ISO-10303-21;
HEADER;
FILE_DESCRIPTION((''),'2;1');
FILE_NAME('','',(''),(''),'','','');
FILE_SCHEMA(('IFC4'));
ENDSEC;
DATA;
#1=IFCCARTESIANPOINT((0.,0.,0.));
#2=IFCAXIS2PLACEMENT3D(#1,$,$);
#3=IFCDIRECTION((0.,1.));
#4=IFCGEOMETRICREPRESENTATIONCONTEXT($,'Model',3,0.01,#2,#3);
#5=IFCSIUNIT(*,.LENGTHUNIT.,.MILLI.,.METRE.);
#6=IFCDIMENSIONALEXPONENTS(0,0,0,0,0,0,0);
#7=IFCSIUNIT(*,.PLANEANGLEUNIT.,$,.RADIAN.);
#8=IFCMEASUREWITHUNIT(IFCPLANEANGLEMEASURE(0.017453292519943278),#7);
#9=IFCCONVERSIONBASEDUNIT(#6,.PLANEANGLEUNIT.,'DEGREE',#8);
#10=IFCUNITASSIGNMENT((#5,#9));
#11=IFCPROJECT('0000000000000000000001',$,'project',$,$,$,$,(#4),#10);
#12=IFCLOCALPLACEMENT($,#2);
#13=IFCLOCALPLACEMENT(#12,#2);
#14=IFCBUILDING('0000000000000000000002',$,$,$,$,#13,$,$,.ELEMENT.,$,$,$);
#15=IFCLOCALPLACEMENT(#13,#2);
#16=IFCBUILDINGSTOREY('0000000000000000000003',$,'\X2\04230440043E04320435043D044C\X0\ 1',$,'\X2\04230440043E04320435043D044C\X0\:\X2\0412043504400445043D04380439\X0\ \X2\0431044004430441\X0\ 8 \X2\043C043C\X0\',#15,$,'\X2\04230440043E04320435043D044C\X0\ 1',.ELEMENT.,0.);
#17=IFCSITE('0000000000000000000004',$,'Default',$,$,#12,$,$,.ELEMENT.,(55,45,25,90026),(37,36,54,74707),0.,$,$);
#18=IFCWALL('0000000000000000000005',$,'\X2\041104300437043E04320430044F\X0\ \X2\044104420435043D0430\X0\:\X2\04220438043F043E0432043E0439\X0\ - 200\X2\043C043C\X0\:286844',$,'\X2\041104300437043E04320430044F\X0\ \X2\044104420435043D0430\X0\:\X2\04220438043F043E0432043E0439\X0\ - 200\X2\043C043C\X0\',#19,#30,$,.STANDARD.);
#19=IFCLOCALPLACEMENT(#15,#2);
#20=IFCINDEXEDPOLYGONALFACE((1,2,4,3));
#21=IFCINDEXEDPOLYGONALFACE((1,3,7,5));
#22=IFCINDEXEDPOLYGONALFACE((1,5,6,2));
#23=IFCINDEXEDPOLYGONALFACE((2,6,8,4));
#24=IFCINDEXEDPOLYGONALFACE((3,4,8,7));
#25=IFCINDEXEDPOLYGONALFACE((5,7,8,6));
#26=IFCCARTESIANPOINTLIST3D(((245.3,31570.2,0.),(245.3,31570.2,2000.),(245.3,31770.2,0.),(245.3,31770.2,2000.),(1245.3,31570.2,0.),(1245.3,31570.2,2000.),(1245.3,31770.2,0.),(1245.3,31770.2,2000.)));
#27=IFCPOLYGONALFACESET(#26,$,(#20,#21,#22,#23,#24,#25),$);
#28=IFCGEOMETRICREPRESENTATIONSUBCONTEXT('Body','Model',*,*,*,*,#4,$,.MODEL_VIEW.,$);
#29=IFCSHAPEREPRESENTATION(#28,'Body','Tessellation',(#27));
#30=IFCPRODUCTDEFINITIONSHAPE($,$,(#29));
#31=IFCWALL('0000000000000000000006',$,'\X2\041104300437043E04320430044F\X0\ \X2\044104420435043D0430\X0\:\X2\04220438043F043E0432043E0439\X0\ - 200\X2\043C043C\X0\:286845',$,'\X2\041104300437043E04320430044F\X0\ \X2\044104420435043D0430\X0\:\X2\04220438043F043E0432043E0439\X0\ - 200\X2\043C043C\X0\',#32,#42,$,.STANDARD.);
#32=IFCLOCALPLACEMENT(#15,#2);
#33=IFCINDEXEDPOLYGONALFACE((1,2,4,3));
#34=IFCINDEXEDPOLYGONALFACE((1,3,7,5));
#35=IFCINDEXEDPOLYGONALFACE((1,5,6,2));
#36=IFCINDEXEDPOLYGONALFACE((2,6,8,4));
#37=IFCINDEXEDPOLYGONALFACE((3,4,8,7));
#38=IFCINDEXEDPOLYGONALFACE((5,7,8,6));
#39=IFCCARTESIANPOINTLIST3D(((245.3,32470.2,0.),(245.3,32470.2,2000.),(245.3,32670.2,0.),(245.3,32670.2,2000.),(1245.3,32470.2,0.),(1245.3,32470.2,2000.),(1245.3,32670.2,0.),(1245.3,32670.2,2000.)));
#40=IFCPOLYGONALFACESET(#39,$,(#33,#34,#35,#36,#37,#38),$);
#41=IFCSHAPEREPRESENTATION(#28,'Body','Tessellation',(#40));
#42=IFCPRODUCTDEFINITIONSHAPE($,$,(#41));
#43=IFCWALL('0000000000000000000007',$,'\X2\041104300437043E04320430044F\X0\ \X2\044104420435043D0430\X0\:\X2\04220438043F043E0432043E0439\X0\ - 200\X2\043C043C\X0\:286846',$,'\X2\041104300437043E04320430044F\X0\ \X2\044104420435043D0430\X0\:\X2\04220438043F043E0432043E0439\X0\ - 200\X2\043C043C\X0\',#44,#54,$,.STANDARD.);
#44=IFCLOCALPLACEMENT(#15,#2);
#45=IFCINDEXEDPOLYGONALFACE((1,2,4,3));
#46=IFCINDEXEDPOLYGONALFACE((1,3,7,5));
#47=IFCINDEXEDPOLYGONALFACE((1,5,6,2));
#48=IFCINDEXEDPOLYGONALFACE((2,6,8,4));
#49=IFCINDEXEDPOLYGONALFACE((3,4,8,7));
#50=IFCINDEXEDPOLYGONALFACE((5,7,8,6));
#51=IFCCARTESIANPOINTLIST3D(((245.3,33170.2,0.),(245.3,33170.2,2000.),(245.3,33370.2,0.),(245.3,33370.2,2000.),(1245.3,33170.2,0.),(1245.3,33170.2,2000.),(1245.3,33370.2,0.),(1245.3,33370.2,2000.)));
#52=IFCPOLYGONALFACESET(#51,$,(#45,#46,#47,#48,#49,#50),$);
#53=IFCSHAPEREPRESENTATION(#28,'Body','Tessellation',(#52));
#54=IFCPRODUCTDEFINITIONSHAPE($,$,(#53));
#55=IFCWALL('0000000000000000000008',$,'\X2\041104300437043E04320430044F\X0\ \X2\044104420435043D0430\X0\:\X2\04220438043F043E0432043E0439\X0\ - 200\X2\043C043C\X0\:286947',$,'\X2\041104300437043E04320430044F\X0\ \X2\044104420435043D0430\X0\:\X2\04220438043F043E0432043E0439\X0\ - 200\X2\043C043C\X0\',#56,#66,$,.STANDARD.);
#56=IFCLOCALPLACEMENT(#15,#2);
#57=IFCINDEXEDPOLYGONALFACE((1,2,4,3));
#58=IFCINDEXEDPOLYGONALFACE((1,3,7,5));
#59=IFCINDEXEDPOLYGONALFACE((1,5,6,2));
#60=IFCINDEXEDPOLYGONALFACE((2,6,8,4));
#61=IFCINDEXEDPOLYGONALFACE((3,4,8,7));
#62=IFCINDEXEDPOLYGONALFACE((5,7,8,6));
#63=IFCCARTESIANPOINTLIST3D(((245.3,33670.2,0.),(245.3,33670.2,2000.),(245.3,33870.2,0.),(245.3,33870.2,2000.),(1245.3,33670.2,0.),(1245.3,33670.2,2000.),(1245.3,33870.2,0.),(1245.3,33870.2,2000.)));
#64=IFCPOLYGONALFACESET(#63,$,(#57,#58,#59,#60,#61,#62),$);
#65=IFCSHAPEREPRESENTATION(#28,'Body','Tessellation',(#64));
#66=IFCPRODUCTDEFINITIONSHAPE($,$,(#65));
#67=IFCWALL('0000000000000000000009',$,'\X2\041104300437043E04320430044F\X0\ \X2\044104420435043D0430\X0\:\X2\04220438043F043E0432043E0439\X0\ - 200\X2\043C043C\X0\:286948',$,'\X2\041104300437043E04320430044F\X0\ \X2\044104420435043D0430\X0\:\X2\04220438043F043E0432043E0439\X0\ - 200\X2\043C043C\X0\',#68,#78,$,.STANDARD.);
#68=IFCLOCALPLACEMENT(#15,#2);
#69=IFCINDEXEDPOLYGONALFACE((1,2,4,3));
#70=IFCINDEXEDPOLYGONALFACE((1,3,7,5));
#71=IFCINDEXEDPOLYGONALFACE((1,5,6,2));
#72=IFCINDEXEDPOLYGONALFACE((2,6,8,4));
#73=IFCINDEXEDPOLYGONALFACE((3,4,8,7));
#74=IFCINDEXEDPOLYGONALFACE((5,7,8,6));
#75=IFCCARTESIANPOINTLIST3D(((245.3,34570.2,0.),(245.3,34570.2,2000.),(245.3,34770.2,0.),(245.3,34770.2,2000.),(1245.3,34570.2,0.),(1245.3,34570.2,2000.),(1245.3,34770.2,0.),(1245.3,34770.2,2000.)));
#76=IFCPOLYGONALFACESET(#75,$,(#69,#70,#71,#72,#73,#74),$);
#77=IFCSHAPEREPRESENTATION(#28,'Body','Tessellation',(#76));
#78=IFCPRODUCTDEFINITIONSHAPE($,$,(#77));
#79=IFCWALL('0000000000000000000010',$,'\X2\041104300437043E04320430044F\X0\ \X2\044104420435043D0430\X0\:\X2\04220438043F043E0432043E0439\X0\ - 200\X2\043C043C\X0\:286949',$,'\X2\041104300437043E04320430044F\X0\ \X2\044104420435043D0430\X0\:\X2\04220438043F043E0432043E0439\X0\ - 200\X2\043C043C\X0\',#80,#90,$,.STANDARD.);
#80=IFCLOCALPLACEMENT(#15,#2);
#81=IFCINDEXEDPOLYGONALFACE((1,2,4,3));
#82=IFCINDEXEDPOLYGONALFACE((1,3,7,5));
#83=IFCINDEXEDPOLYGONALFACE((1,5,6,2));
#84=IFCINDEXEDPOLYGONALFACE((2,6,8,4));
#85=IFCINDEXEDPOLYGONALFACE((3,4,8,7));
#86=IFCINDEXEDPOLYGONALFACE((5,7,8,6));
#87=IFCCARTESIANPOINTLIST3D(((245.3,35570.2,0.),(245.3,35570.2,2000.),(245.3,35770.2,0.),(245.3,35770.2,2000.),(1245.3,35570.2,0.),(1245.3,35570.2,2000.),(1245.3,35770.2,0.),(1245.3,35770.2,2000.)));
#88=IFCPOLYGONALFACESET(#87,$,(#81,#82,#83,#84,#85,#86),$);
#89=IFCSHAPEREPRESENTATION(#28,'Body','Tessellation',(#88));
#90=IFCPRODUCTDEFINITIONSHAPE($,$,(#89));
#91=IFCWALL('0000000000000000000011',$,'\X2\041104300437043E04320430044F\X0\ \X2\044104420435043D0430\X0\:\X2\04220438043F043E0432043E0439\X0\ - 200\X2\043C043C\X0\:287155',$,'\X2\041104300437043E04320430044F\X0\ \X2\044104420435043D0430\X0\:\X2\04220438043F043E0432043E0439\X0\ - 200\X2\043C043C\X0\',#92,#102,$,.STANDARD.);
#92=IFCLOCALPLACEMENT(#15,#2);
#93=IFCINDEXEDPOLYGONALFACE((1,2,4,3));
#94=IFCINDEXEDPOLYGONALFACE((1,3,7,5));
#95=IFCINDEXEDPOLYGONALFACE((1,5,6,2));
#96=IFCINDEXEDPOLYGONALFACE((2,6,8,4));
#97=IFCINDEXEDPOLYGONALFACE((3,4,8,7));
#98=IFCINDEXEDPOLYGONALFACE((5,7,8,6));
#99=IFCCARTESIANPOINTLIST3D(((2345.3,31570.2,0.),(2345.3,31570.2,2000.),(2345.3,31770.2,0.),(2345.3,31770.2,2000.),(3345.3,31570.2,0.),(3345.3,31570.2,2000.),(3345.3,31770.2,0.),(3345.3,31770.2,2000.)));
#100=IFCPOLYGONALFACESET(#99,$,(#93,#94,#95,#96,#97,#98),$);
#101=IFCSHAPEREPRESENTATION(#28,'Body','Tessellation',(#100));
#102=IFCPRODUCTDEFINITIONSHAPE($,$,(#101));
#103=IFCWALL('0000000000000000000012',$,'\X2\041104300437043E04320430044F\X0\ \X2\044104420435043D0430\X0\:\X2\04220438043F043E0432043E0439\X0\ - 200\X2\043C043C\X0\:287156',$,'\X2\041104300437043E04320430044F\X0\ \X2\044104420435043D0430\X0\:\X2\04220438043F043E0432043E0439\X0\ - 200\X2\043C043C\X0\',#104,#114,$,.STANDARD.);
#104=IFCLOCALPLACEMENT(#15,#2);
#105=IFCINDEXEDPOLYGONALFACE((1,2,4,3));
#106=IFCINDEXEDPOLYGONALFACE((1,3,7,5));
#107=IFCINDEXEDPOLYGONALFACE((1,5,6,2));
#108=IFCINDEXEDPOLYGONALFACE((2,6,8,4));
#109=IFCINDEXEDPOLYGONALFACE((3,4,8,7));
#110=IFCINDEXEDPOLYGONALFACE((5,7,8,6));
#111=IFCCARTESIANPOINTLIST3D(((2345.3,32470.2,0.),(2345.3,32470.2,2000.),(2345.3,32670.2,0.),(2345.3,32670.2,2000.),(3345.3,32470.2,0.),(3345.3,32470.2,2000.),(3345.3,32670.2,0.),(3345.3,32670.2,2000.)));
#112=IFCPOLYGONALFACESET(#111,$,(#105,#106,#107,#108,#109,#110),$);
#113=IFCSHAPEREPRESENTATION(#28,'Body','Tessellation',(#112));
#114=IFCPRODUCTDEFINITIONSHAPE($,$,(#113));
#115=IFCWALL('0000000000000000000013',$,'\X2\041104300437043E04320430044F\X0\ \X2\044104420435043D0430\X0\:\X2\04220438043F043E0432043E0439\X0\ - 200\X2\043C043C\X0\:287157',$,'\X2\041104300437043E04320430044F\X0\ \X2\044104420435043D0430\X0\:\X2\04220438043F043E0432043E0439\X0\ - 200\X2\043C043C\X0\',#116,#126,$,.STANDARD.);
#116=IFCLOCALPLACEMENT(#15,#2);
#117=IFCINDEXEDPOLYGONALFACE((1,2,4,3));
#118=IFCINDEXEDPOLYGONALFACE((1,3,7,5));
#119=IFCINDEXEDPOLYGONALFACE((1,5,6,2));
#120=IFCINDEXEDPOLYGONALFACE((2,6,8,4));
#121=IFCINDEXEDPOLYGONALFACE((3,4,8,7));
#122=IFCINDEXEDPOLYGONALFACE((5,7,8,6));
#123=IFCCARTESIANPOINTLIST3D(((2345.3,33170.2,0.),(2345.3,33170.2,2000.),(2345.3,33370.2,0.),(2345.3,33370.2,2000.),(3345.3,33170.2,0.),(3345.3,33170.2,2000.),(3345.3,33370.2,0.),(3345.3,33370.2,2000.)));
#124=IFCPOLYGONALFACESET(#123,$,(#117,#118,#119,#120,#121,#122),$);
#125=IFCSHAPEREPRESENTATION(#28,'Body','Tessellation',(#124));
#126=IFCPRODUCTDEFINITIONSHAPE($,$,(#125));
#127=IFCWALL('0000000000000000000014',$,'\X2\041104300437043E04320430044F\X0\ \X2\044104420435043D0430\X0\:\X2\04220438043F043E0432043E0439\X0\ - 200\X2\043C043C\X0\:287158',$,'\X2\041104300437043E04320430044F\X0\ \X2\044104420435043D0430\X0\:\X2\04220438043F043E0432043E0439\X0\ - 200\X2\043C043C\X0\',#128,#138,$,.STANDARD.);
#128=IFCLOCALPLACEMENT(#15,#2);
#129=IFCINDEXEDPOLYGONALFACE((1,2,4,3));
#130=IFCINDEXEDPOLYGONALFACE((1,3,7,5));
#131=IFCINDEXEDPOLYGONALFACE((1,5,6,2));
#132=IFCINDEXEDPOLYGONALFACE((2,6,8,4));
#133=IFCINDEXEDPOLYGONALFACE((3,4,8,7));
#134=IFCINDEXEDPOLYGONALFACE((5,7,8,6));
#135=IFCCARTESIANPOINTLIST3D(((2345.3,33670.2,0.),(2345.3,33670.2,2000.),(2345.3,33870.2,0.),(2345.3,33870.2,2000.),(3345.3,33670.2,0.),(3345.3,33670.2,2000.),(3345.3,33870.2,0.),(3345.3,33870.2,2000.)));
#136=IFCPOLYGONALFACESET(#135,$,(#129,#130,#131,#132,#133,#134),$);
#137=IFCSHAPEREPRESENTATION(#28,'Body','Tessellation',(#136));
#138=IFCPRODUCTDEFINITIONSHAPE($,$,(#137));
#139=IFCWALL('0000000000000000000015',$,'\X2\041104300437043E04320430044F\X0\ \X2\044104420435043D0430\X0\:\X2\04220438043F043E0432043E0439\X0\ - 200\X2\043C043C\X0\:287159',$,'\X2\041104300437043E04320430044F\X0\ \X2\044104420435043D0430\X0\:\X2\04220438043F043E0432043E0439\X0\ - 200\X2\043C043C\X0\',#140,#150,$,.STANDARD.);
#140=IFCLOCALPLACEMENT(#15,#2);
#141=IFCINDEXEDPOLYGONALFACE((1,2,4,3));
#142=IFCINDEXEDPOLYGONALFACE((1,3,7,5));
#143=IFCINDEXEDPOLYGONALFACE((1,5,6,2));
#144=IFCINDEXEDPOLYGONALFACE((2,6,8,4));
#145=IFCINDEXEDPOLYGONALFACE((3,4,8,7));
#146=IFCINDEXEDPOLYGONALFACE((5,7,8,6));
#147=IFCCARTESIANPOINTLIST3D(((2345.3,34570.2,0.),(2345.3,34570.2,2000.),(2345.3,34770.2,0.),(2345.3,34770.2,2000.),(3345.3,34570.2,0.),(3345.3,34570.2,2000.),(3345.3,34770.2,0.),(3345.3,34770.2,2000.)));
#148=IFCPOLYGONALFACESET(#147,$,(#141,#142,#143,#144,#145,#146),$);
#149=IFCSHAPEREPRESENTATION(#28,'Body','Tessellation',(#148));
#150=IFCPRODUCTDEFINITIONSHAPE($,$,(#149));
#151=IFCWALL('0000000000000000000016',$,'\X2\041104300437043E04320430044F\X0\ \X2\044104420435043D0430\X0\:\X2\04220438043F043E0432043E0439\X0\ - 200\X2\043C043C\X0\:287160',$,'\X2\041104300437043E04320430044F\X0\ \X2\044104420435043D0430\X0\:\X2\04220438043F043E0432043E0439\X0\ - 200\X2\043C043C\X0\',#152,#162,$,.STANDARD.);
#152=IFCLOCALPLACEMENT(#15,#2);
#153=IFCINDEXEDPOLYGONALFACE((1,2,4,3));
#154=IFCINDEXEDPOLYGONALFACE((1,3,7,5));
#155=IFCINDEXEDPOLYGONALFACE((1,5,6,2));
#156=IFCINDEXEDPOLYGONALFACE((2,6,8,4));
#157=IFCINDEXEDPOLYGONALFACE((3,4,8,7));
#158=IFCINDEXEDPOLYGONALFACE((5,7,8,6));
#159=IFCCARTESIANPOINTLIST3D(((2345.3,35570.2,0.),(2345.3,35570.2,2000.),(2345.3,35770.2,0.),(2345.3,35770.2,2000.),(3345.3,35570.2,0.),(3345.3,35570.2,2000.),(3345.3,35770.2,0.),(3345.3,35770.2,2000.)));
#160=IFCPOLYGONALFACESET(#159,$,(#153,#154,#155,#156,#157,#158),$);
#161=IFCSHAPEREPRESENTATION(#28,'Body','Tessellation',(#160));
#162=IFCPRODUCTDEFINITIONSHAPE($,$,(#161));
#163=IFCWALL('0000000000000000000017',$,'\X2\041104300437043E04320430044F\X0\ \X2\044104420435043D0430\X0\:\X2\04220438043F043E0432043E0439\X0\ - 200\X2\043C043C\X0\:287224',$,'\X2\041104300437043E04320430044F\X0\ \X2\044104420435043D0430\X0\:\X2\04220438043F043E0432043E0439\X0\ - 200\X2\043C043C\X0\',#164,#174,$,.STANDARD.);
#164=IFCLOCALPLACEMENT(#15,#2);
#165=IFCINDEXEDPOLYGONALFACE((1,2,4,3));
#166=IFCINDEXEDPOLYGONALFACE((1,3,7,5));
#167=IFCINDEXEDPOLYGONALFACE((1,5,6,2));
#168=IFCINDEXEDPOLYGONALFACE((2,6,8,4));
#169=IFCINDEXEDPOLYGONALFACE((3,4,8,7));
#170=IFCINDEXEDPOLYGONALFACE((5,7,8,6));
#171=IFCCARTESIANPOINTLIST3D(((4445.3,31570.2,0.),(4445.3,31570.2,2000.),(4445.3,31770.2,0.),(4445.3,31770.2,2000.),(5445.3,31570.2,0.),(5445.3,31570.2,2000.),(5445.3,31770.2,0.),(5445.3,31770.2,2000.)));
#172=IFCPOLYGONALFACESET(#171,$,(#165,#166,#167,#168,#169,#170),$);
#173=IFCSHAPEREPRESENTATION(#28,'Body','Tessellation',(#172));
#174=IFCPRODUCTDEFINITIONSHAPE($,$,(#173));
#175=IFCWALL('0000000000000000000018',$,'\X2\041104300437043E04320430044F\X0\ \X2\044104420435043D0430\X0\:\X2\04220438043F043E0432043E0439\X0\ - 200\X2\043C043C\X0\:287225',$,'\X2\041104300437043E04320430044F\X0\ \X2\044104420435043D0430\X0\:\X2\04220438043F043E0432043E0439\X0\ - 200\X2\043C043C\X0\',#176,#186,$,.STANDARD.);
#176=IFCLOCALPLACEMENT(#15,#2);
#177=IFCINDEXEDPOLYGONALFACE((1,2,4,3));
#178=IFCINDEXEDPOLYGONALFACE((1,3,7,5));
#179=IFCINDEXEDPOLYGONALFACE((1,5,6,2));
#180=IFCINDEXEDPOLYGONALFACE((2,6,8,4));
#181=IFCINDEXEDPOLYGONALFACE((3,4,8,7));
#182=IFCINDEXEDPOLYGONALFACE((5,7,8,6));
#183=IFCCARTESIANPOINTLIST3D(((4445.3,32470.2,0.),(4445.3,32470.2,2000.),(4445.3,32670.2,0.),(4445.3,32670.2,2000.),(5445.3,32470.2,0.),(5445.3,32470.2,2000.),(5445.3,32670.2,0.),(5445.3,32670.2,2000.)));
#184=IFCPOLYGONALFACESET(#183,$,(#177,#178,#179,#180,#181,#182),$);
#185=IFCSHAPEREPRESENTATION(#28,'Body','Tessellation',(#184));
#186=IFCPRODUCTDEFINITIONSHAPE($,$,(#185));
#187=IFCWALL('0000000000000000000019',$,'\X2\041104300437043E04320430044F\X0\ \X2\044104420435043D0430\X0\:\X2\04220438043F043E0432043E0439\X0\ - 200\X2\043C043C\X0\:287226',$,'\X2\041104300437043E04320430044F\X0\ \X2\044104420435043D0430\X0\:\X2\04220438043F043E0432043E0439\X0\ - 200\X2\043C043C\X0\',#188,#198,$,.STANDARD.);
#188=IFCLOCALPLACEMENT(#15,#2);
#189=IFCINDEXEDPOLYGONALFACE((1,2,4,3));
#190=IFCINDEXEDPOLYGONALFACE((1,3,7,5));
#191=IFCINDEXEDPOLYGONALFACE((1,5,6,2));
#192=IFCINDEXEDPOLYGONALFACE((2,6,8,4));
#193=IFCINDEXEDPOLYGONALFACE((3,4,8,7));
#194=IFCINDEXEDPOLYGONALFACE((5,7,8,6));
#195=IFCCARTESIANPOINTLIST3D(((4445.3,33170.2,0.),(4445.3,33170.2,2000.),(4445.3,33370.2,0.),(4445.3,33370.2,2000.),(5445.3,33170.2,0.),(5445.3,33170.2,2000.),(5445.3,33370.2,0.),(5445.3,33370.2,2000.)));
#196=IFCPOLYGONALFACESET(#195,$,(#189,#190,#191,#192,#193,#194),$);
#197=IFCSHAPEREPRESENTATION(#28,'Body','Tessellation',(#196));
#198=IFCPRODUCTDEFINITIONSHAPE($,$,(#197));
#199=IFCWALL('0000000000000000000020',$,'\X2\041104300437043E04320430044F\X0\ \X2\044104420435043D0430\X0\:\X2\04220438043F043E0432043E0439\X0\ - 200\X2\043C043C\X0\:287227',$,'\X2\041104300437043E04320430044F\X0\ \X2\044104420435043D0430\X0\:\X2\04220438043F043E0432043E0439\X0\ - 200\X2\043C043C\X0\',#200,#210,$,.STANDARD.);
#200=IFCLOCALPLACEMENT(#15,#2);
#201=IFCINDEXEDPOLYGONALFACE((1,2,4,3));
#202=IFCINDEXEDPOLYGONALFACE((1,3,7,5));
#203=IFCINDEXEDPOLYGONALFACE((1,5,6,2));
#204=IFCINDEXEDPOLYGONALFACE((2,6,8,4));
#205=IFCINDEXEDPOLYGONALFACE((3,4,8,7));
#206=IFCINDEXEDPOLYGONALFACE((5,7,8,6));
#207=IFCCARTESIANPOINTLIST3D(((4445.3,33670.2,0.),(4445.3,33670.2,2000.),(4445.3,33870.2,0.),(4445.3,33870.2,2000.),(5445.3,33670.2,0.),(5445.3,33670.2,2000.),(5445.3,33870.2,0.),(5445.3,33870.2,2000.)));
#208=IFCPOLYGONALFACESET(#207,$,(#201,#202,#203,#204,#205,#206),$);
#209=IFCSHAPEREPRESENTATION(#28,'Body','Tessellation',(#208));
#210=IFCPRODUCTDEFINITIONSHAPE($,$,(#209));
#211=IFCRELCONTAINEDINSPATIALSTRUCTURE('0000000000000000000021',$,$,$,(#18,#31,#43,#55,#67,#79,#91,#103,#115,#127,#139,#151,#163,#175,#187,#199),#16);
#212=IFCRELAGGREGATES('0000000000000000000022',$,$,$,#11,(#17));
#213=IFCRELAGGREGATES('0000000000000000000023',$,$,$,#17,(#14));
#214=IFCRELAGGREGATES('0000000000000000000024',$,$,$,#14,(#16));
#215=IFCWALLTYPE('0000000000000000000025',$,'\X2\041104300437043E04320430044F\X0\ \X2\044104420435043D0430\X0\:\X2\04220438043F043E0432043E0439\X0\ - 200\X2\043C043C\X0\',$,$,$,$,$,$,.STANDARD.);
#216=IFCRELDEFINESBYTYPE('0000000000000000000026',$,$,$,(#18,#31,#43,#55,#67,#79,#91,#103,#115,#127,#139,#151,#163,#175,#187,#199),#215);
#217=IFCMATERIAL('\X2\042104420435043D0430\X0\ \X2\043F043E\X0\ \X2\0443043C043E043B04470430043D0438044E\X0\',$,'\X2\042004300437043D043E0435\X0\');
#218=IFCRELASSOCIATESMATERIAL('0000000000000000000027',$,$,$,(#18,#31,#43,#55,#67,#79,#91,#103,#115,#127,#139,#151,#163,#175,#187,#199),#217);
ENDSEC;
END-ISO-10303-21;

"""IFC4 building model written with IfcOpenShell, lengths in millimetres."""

from ifc_helpers import new_model, entity, si_unit, converted_unit, direction, frame, origin, place, context, subcontext, project, spatial, indexed_curve, outline, extrude, material, type_object, element, save


model = new_model("IFC4")

# Units and contexts
model_context = context("Model", 3, precision=0.01, world=origin(), true_north=direction((0.0, 1.0)))
body_context = subcontext(model_context, "Body", "Model", "MODEL_VIEW")
ifc_project = project(units=[si_unit("LENGTHUNIT", "METRE", prefix="MILLI"), converted_unit("PLANEANGLEUNIT", "DEGREE", entity("IfcPlaneAngleMeasure", 0.017453292519943278), si_unit("PLANEANGLEUNIT", "RADIAN"), dimensions=[0, 0, 0, 0, 0, 0, 0])], contexts=[model_context])

# Site, building, storey
site_placement = place(None, origin())
site = spatial("IfcSite", under=ifc_project, at=site_placement, Name="Default", CompositionType="ELEMENT", RefLatitude=(55, 45, 25, 90026), RefLongitude=(37, 36, 54, 74707), RefElevation=0.0)
building_placement = place(site_placement, origin())
building = spatial("IfcBuilding", under=site, at=building_placement, CompositionType="ELEMENT")
storey_placement = place(building_placement, origin())
storey = spatial("IfcBuildingStorey", under=building, at=storey_placement, Name="Уровень 1", ObjectType="Уровень:Верхний брус 8 мм", LongName="Уровень 1", CompositionType="ELEMENT", Elevation=0.0)

# Walls
ifc_material = material(Name="Стена по умолчанию", Category="Разное")
wall_type = type_object("IfcWallType", Name="Базовая стена:Типовой - 200мм", PredefinedType="STANDARD")
wall_1_placement = place(storey_placement, frame((245.3, 31670.2, 0.0)))
element("IfcWall", 1, at=wall_1_placement, inside=storey, type_object=wall_type, material=ifc_material, Name="Базовая стена:Типовой - 200мм:286844", ObjectType="Базовая стена:Типовой - 200мм", PredefinedType="STANDARD", context=body_context, shape_type="SweptSolid", body=[
    extrude(outline(indexed_curve([(1000.0, 100.0), (0.0, 100.0), (0.0, -100.0), (1000.0, -100.0), (1000.0, 100.0)], self_intersect=False)), origin(), (0.0, 0.0, 1.0), 2000.0),
])
for number, where, name in (
    (2, (245.3, 32570.2, 0.0), "Базовая стена:Типовой - 200мм:286845"),
    (3, (245.3, 33270.2, 0.0), "Базовая стена:Типовой - 200мм:286846"),
):
    element("IfcWall", number, at=place(storey_placement, frame(where)), inside=storey, type_object=wall_type, material=ifc_material, Name=name, ObjectType="Базовая стена:Типовой - 200мм", PredefinedType="STANDARD", context=body_context, shape_type="SweptSolid", body=[
        extrude(outline(indexed_curve([(1000.0, 100.0), (0.0, 100.0), (0.0, -100.0), (1000.0, -100.0), (1000.0, 100.0)], self_intersect=False)), origin(), (0.0, 0.0, 1.0), 2000.0),
    ])
for number, where, name in (
    (4, (245.3, 33770.2, 0.0), "Базовая стена:Типовой - 200мм:286947"),
    (5, (245.3, 34670.2, 0.0), "Базовая стена:Типовой - 200мм:286948"),
    (6, (245.3, 35670.2, 0.0), "Базовая стена:Типовой - 200мм:286949"),
):
    element("IfcWall", number, at=place(storey_placement, frame(where)), inside=storey, type_object=wall_type, material=ifc_material, Name=name, ObjectType="Базовая стена:Типовой - 200мм", PredefinedType="STANDARD", context=body_context, shape_type="SweptSolid", body=[
        extrude(outline(indexed_curve([(1000.0, 100.0), (0.0, 100.0), (0.0, -100.0), (1000.0, -100.0), (1000.0, 100.0)], self_intersect=False)), origin(), (0.0, 0.0, 1.0), 2000.0),
    ])
wall_2_placement = place(storey_placement, frame((2345.3, 31670.2, 0.0)))
element("IfcWall", 7, at=wall_2_placement, inside=storey, type_object=wall_type, material=ifc_material, Name="Базовая стена:Типовой - 200мм:287155", ObjectType="Базовая стена:Типовой - 200мм", PredefinedType="STANDARD", context=body_context, shape_type="SweptSolid", body=[
    extrude(outline(indexed_curve([(1000.0, 100.0), (0.0, 100.0), (0.0, -100.0), (1000.0, -100.0), (1000.0, 100.0)], self_intersect=False)), origin(), (0.0, 0.0, 1.0), 2000.0),
])
for number, where, name in (
    (8, (2345.3, 32570.2, 0.0), "Базовая стена:Типовой - 200мм:287156"),
    (9, (2345.3, 33270.2, 0.0), "Базовая стена:Типовой - 200мм:287157"),
):
    element("IfcWall", number, at=place(storey_placement, frame(where)), inside=storey, type_object=wall_type, material=ifc_material, Name=name, ObjectType="Базовая стена:Типовой - 200мм", PredefinedType="STANDARD", context=body_context, shape_type="SweptSolid", body=[
        extrude(outline(indexed_curve([(1000.0, 100.0), (0.0, 100.0), (0.0, -100.0), (1000.0, -100.0), (1000.0, 100.0)], self_intersect=False)), origin(), (0.0, 0.0, 1.0), 2000.0),
    ])
for number, where, name in (
    (10, (2345.3, 33770.2, 0.0), "Базовая стена:Типовой - 200мм:287158"),
    (11, (2345.3, 34670.2, 0.0), "Базовая стена:Типовой - 200мм:287159"),
    (12, (2345.3, 35670.2, 0.0), "Базовая стена:Типовой - 200мм:287160"),
):
    element("IfcWall", number, at=place(storey_placement, frame(where)), inside=storey, type_object=wall_type, material=ifc_material, Name=name, ObjectType="Базовая стена:Типовой - 200мм", PredefinedType="STANDARD", context=body_context, shape_type="SweptSolid", body=[
        extrude(outline(indexed_curve([(1000.0, 100.0), (0.0, 100.0), (0.0, -100.0), (1000.0, -100.0), (1000.0, 100.0)], self_intersect=False)), origin(), (0.0, 0.0, 1.0), 2000.0),
    ])
wall_3_placement = place(storey_placement, frame((4445.3, 31670.2, 0.0)))
element("IfcWall", 13, at=wall_3_placement, inside=storey, type_object=wall_type, material=ifc_material, Name="Базовая стена:Типовой - 200мм:287224", ObjectType="Базовая стена:Типовой - 200мм", PredefinedType="STANDARD", context=body_context, shape_type="SweptSolid", body=[
    extrude(outline(indexed_curve([(1000.0, 100.0), (0.0, 100.0), (0.0, -100.0), (1000.0, -100.0), (1000.0, 100.0)], self_intersect=False)), origin(), (0.0, 0.0, 1.0), 2000.0),
])
for number, where, name in (
    (14, (4445.3, 32570.2, 0.0), "Базовая стена:Типовой - 200мм:287225"),
    (15, (4445.3, 33270.2, 0.0), "Базовая стена:Типовой - 200мм:287226"),
):
    element("IfcWall", number, at=place(storey_placement, frame(where)), inside=storey, type_object=wall_type, material=ifc_material, Name=name, ObjectType="Базовая стена:Типовой - 200мм", PredefinedType="STANDARD", context=body_context, shape_type="SweptSolid", body=[
        extrude(outline(indexed_curve([(1000.0, 100.0), (0.0, 100.0), (0.0, -100.0), (1000.0, -100.0), (1000.0, 100.0)], self_intersect=False)), origin(), (0.0, 0.0, 1.0), 2000.0),
    ])
for number, where, name in (
    (16, (4445.3, 33770.2, 0.0), "Базовая стена:Типовой - 200мм:287227"),
):
    element("IfcWall", number, at=place(storey_placement, frame(where)), inside=storey, type_object=wall_type, material=ifc_material, Name=name, ObjectType="Базовая стена:Типовой - 200мм", PredefinedType="STANDARD", context=body_context, shape_type="SweptSolid", body=[
        extrude(outline(indexed_curve([(1000.0, 100.0), (0.0, 100.0), (0.0, -100.0), (1000.0, -100.0), (1000.0, 100.0)], self_intersect=False)), origin(), (0.0, 0.0, 1.0), 2000.0),
    ])

save(model, "model.ifc")
